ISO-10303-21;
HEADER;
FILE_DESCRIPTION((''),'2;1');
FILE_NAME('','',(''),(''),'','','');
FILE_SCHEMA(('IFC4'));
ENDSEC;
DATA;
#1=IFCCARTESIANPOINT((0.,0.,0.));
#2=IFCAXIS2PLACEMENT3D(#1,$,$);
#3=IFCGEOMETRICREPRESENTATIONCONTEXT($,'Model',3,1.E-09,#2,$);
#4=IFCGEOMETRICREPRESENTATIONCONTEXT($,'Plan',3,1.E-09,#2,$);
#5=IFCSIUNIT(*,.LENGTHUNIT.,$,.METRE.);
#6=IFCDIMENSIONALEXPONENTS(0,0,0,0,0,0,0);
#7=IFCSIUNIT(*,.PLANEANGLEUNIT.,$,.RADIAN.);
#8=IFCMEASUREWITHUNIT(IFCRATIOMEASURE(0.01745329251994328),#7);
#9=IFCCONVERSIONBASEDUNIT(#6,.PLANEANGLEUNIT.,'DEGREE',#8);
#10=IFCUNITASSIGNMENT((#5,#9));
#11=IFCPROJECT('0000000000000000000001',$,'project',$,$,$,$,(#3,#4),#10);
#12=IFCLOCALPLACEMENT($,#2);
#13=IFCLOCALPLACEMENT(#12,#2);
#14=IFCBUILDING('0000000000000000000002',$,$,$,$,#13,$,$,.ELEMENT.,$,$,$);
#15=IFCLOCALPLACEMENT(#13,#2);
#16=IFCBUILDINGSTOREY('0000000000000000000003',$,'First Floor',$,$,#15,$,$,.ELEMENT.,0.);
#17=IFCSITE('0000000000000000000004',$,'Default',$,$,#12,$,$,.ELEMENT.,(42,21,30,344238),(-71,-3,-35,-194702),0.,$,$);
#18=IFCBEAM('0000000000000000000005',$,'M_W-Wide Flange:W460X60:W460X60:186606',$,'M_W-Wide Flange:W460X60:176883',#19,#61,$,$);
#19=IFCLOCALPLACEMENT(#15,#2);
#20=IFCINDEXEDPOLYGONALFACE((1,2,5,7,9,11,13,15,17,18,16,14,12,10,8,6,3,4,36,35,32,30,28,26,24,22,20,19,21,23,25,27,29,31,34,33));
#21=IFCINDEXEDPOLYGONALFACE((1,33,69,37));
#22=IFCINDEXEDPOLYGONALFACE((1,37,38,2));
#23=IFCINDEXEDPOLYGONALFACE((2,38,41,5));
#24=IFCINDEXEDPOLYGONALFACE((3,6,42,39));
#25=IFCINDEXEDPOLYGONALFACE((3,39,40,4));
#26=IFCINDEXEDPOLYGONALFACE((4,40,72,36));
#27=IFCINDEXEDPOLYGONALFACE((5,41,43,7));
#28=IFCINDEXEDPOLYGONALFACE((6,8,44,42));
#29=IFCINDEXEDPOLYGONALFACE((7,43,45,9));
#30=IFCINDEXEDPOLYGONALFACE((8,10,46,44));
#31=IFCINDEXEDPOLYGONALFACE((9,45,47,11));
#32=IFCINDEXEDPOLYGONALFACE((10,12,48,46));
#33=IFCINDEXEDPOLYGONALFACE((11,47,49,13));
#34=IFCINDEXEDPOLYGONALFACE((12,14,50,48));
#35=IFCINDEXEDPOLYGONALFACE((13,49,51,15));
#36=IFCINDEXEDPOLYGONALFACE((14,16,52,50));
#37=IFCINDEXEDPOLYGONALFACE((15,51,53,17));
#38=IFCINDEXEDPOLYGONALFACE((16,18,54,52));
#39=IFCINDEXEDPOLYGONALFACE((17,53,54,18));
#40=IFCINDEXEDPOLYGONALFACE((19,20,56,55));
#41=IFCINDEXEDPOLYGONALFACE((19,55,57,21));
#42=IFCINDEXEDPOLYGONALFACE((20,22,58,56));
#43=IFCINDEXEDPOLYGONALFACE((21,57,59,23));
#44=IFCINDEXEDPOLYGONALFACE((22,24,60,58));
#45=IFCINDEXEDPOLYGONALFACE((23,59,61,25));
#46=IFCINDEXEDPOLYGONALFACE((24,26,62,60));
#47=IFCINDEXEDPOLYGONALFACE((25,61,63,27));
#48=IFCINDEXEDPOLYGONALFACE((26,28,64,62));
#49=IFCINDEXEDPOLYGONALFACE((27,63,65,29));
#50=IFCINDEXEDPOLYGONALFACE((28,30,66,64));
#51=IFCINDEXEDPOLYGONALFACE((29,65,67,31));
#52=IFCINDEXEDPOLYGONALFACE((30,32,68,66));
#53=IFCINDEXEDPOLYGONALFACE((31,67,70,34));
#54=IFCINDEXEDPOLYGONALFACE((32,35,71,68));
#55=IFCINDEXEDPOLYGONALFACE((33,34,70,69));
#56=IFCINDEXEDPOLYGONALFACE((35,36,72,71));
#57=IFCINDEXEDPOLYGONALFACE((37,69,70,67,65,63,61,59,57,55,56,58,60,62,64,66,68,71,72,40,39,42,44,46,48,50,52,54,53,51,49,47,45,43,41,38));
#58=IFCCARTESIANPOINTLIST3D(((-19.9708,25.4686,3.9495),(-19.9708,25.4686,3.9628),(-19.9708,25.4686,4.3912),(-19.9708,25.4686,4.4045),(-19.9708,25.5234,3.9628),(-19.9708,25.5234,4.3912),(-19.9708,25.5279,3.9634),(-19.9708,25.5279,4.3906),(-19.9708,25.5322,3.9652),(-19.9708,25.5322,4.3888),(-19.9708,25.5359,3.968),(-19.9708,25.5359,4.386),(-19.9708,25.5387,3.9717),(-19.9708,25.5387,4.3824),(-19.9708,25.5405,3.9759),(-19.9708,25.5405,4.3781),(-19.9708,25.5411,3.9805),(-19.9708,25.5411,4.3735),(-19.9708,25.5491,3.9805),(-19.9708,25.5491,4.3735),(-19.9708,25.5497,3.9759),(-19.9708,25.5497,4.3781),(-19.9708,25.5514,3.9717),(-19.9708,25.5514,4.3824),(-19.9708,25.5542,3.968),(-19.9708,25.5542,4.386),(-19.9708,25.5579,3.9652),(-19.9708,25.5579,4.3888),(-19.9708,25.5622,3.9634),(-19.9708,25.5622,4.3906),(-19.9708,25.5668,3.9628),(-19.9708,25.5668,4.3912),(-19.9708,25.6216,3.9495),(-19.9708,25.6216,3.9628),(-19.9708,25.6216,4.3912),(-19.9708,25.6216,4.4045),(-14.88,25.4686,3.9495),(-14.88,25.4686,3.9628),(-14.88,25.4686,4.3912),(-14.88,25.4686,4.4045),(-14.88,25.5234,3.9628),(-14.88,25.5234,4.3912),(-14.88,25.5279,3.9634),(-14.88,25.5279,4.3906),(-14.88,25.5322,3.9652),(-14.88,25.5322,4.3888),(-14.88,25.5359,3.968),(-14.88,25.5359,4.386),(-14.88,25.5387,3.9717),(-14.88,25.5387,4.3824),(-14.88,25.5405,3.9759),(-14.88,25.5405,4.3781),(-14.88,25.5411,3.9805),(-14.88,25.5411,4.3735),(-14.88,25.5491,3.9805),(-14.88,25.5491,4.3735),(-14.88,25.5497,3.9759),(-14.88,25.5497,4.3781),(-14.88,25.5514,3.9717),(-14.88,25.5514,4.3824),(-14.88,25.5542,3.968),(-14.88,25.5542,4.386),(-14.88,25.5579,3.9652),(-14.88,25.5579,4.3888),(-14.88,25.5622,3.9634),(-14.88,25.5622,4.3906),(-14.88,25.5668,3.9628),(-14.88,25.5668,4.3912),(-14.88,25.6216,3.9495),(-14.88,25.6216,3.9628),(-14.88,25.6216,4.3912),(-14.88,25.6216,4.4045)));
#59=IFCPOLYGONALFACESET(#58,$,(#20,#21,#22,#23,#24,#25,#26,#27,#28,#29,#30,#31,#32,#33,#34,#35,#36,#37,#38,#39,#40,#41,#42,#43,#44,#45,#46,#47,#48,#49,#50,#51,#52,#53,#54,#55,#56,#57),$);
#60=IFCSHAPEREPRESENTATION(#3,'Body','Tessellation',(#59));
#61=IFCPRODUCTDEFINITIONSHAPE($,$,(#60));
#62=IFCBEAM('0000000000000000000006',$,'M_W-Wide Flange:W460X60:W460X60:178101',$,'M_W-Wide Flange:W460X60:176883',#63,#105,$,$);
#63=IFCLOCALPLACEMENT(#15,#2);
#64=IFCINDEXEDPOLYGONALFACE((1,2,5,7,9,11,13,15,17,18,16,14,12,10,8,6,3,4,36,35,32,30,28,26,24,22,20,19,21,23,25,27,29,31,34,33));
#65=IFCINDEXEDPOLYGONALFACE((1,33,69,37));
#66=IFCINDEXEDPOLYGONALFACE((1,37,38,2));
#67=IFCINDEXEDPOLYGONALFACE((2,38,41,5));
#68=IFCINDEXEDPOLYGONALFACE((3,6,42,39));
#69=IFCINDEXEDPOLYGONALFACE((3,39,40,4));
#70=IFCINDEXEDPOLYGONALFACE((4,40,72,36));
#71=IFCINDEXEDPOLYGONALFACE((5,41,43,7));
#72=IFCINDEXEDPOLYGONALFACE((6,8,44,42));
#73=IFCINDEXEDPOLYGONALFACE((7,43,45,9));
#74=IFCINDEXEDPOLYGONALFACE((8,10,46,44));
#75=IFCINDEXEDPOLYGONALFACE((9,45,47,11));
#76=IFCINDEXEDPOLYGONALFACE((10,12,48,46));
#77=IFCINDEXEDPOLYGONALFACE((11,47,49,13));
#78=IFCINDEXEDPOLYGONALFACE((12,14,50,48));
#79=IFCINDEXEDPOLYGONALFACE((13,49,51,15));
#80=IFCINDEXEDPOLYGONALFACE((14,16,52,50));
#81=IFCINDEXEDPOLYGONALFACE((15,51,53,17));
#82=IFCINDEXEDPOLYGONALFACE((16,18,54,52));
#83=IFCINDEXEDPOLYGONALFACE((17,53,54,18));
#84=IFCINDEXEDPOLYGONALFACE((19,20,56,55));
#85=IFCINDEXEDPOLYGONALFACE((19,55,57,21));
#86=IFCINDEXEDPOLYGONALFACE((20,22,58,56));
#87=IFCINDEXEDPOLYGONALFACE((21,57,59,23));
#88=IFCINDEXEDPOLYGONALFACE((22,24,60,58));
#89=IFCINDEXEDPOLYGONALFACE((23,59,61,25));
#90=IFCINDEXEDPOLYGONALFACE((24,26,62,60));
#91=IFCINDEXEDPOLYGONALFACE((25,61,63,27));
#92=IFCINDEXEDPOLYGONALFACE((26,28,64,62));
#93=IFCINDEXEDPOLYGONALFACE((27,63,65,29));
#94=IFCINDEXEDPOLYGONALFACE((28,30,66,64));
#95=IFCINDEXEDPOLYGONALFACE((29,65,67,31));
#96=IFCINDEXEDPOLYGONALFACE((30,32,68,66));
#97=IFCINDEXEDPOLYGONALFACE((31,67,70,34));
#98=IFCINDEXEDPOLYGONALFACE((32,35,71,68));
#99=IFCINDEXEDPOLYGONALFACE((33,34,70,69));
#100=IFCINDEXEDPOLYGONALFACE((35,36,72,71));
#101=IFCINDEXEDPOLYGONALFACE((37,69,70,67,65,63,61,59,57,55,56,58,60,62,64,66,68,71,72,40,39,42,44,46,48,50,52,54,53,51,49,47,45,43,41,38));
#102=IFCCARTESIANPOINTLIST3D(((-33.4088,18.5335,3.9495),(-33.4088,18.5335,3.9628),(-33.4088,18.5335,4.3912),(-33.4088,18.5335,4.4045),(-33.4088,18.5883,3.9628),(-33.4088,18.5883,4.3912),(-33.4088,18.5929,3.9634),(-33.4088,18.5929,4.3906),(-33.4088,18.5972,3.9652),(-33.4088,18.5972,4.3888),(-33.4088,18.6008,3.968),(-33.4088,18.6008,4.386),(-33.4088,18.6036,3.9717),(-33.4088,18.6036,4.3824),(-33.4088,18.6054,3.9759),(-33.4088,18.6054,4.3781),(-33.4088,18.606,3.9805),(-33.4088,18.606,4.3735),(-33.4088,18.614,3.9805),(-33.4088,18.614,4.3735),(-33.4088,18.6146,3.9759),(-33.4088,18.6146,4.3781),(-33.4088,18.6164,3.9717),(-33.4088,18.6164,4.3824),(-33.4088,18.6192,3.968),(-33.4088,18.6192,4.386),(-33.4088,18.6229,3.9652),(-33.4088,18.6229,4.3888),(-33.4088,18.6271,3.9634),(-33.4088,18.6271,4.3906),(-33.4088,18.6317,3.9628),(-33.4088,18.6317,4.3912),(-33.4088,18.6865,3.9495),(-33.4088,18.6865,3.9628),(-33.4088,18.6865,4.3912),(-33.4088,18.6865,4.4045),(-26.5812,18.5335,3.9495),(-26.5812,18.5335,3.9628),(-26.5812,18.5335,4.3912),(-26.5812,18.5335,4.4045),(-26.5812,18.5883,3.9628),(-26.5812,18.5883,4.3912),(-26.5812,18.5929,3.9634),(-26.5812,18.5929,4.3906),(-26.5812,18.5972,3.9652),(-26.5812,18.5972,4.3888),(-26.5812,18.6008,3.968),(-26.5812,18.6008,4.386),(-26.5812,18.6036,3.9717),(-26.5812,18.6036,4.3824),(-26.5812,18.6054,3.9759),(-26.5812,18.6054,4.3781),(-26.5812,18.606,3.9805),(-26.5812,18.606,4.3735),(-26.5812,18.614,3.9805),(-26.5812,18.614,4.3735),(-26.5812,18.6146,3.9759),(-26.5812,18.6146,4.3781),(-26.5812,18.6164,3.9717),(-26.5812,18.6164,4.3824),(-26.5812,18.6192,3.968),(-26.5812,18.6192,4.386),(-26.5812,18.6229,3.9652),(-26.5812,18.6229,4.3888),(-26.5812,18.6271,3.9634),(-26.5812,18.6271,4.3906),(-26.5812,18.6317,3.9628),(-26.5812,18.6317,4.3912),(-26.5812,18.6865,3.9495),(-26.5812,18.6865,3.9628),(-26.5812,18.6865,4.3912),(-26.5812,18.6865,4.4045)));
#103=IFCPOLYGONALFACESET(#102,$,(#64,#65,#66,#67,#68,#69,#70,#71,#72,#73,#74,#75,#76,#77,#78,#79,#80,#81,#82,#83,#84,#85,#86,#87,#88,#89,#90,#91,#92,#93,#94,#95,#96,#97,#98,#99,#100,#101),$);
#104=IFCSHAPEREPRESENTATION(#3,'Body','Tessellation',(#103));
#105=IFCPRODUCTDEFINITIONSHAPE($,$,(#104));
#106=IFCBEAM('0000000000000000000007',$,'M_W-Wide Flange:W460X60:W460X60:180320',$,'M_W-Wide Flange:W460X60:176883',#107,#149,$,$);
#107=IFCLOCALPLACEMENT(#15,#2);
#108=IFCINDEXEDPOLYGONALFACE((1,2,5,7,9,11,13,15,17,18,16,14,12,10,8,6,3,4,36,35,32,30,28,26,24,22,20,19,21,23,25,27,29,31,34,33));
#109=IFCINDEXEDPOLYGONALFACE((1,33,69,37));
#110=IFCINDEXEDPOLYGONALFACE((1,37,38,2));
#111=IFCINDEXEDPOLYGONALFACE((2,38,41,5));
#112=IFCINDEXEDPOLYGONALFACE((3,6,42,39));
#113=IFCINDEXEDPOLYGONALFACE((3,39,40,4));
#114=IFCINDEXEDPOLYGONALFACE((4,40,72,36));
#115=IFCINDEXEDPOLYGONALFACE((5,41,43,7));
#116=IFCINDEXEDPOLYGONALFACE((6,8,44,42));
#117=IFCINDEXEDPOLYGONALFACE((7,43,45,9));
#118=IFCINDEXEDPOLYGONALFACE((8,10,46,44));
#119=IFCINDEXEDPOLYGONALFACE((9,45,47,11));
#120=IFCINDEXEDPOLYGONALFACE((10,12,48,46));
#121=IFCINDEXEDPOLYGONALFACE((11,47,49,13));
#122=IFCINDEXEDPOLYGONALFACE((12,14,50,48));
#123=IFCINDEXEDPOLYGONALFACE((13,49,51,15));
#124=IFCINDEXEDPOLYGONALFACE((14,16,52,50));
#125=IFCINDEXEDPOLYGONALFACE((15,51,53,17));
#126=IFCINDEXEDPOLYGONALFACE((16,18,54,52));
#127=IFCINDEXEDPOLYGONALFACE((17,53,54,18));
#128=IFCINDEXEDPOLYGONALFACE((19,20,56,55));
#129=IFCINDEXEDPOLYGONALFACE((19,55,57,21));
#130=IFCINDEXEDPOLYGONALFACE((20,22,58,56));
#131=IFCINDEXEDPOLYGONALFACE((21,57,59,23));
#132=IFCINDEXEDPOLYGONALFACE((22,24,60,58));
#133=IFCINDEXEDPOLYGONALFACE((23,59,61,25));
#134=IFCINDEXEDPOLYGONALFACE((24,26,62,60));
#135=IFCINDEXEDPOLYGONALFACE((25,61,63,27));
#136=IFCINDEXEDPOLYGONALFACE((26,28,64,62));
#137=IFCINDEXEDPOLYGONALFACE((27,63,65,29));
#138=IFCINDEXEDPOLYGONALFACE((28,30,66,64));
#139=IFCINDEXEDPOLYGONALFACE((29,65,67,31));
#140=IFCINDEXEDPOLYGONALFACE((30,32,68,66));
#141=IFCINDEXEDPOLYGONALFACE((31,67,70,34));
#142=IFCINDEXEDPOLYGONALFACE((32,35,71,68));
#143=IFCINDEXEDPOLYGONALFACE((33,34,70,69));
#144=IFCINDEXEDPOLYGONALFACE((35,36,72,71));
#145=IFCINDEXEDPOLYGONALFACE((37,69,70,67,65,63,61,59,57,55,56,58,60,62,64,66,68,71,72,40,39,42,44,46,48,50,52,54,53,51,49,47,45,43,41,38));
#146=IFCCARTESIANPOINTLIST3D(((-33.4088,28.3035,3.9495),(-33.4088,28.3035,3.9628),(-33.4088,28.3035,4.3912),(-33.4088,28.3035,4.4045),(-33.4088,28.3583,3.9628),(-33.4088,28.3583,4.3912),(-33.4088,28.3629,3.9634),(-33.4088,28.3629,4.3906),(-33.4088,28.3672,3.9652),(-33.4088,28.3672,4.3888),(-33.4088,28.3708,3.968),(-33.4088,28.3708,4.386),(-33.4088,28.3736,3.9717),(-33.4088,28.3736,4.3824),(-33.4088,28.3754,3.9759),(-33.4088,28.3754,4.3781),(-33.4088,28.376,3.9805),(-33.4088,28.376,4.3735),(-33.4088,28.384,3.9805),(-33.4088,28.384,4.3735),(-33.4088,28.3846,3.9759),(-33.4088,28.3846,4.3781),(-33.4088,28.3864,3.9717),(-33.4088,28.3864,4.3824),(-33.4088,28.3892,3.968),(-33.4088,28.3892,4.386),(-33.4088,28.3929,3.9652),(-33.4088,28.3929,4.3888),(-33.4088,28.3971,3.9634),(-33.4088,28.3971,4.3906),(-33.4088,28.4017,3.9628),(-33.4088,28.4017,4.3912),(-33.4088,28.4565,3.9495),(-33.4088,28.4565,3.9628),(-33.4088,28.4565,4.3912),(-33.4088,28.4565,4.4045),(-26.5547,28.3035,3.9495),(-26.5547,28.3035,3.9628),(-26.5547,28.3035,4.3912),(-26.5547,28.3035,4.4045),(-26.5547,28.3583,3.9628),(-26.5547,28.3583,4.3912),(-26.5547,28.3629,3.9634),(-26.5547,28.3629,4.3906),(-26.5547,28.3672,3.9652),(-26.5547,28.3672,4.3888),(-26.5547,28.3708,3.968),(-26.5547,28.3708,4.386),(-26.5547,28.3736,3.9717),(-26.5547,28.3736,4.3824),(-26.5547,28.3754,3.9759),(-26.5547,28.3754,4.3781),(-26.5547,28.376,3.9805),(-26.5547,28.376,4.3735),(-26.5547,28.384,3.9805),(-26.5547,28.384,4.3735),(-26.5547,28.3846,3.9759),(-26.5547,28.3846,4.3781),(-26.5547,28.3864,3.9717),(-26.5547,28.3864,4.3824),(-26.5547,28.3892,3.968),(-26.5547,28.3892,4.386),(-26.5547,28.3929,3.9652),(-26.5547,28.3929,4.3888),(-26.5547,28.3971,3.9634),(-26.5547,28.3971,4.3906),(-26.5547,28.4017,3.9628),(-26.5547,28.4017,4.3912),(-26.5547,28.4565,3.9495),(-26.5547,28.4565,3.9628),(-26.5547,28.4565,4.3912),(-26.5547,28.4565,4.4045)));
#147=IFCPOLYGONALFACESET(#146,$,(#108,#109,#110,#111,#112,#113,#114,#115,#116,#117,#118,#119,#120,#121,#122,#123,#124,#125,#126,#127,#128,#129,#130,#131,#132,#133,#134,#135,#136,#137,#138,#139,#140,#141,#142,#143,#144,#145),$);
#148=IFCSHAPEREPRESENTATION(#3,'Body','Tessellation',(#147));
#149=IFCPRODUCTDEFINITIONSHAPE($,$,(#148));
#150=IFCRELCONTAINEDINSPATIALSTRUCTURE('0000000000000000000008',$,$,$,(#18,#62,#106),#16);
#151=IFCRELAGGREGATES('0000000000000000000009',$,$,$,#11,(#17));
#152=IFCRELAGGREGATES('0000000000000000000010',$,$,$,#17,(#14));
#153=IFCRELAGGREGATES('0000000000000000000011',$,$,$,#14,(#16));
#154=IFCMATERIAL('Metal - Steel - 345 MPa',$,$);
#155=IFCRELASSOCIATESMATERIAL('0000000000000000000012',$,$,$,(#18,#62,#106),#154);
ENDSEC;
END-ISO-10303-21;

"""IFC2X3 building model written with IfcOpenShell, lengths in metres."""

from ifc_helpers import new_model, entity, si_unit, converted_unit, frame, frame_2d, origin, place, context, project, spatial, polyline, circle_curve, parameter, trimmed, segment, composite_curve, outline, extrude, material, element, save


model = new_model("IFC2X3")

# Units and contexts
model_context = context("Model", 3, precision=1e-09, world=origin())
plan_context = context("Plan", 3, precision=1e-09, world=origin())
ifc_project = project(units=[si_unit("LENGTHUNIT", "METRE"), converted_unit("PLANEANGLEUNIT", "DEGREE", entity("IfcRatioMeasure", 0.01745329251994328), si_unit("PLANEANGLEUNIT", "RADIAN"), dimensions=[0, 0, 0, 0, 0, 0, 0])], contexts=[model_context, plan_context])

# Site, building, storey
site_placement = place(None, origin())
site = spatial("IfcSite", under=ifc_project, at=site_placement, Name="Default", CompositionType="ELEMENT", RefLatitude=(42, 21, 30, 344238), RefLongitude=(-71, -3, -35, -194702), RefElevation=0.0)
building_placement = place(site_placement, origin())
building = spatial("IfcBuilding", under=site, at=building_placement, CompositionType="ELEMENT")
storey_placement = place(building_placement, origin())
storey = spatial("IfcBuildingStorey", under=building, at=storey_placement, Name="First Floor", CompositionType="ELEMENT", Elevation=0.0)

# Beams
ifc_material_1 = material(Name="Metal - Steel - 345 MPa")
beam_1_placement = place(storey_placement, frame((-19.7579, 25.5451, 4.4045), z_axis=(0.0, 0.0, 1.0), x_axis=(0.0, -1.0, 0.0)))
element("IfcBeam", 1, at=beam_1_placement, inside=storey, material=ifc_material_1, Name="M_W-Wide Flange:W460X60:W460X60:186606", ObjectType="M_W-Wide Flange:W460X60:176883", context=model_context, shape_type="SweptSolid", body=[
    extrude(outline(composite_curve([segment(polyline([(-0.0765, -0.2142), (-0.0765, -0.2275)]), True, "CONTINUOUS"), segment(polyline([(-0.0765, -0.2275), (0.0765, -0.2275)]), True, "CONTINUOUS"), segment(polyline([(0.0765, -0.2275), (0.0765, -0.2142)]), True, "CONTINUOUS"), segment(polyline([(0.0765, -0.2142), (0.0217, -0.2142)]), True, "CONTINUOUS"), segment(trimmed(circle_curve(frame_2d((0.0217, -0.1965), x_axis=(1.0, 0.0)), 0.0177), [parameter(180.0)], [parameter(270.0)], True, "PARAMETER"), False, "CONTINUOUS"), segment(polyline([(0.004, -0.1965), (0.004, 0.1965)]), True, "CONTINUOUS"), segment(trimmed(circle_curve(frame_2d((0.0217, 0.1965), x_axis=(1.0, 0.0)), 0.0177), [parameter(90.0)], [parameter(180.0)], True, "PARAMETER"), False, "CONTINUOUS"), segment(polyline([(0.0217, 0.2142), (0.0765, 0.2142)]), True, "CONTINUOUS"), segment(polyline([(0.0765, 0.2142), (0.0765, 0.2275)]), True, "CONTINUOUS"), segment(polyline([(0.0765, 0.2275), (-0.0765, 0.2275)]), True, "CONTINUOUS"), segment(polyline([(-0.0765, 0.2275), (-0.0765, 0.2142)]), True, "CONTINUOUS"), segment(polyline([(-0.0765, 0.2142), (-0.0217, 0.2142)]), True, "CONTINUOUS"), segment(trimmed(circle_curve(frame_2d((-0.0217, 0.1965), x_axis=(1.0, 0.0)), 0.0177), [parameter(360.0)], [parameter(90.0)], True, "PARAMETER"), False, "CONTINUOUS"), segment(polyline([(-0.004, 0.1965), (-0.004, -0.1965)]), True, "CONTINUOUS"), segment(trimmed(circle_curve(frame_2d((-0.0217, -0.1965), x_axis=(1.0, 0.0)), 0.0177), [parameter(270.0)], [parameter(0.0)], True, "PARAMETER"), False, "CONTINUOUS"), segment(polyline([(-0.0217, -0.2142), (-0.0765, -0.2142)]), True, "CONTINUOUS")], self_intersect=False)), frame((0.0, -0.2129, -0.2275), z_axis=(0.0, -1.0, 0.0), x_axis=(1.0, 0.0, 0.0)), (0.0, 0.0, -1.0), 5.0908),
])
beam_2_placement = place(storey_placement, frame((-33.5519, 18.61, 4.4045), z_axis=(0.0, 0.0, 1.0), x_axis=(0.0, -1.0, 0.0)))
element("IfcBeam", 2, at=beam_2_placement, inside=storey, material=ifc_material_1, Name="M_W-Wide Flange:W460X60:W460X60:178101", ObjectType="M_W-Wide Flange:W460X60:176883", context=model_context, shape_type="SweptSolid", body=[
    extrude(outline(composite_curve([segment(polyline([(-0.0765, -0.2142), (-0.0765, -0.2275)]), True, "CONTINUOUS"), segment(polyline([(-0.0765, -0.2275), (0.0765, -0.2275)]), True, "CONTINUOUS"), segment(polyline([(0.0765, -0.2275), (0.0765, -0.2142)]), True, "CONTINUOUS"), segment(polyline([(0.0765, -0.2142), (0.0217, -0.2142)]), True, "CONTINUOUS"), segment(trimmed(circle_curve(frame_2d((0.0217, -0.1965), x_axis=(0.0, -1.0)), 0.0177), [parameter(270.0)], [parameter(360.0)], True, "PARAMETER"), False, "CONTINUOUS"), segment(polyline([(0.004, -0.1965), (0.004, 0.1965)]), True, "CONTINUOUS"), segment(trimmed(circle_curve(frame_2d((0.0217, 0.1965), x_axis=(-1.0, 0.0)), 0.0177), [parameter(270.0)], [parameter(360.0)], True, "PARAMETER"), False, "CONTINUOUS"), segment(polyline([(0.0217, 0.2142), (0.0765, 0.2142)]), True, "CONTINUOUS"), segment(polyline([(0.0765, 0.2142), (0.0765, 0.2275)]), True, "CONTINUOUS"), segment(polyline([(0.0765, 0.2275), (-0.0765, 0.2275)]), True, "CONTINUOUS"), segment(polyline([(-0.0765, 0.2275), (-0.0765, 0.2142)]), True, "CONTINUOUS"), segment(polyline([(-0.0765, 0.2142), (-0.0217, 0.2142)]), True, "CONTINUOUS"), segment(trimmed(circle_curve(frame_2d((-0.0217, 0.1965), x_axis=(0.0, 1.0)), 0.0177), [parameter(270.0)], [parameter(360.0)], True, "PARAMETER"), False, "CONTINUOUS"), segment(polyline([(-0.004, 0.1965), (-0.004, -0.1965)]), True, "CONTINUOUS"), segment(trimmed(circle_curve(frame_2d((-0.0217, -0.1965), x_axis=(1.0, 0.0)), 0.0177), [parameter(270.0)], [parameter(0.0)], True, "PARAMETER"), False, "CONTINUOUS"), segment(polyline([(-0.0217, -0.2142), (-0.0765, -0.2142)]), True, "CONTINUOUS")], self_intersect=False)), frame((0.0, 0.1431, -0.2275), z_axis=(0.0, -1.0, 0.0), x_axis=(1.0, 0.0, 0.0)), (0.0, 0.0, -1.0), 6.8276),
])
beam_3_placement = place(storey_placement, frame((-26.4381, 28.38, 4.4045), z_axis=(0.0, 0.0, 1.0), x_axis=(0.0, 1.0, 0.0)))
element("IfcBeam", 3, at=beam_3_placement, inside=storey, material=ifc_material_1, Name="M_W-Wide Flange:W460X60:W460X60:180320", ObjectType="M_W-Wide Flange:W460X60:176883", context=model_context, shape_type="SweptSolid", body=[
    extrude(outline(composite_curve([segment(polyline([(0.2142, -0.0765), (0.2275, -0.0765)]), True, "CONTINUOUS"), segment(polyline([(0.2275, -0.0765), (0.2275, 0.0765)]), True, "CONTINUOUS"), segment(polyline([(0.2275, 0.0765), (0.2142, 0.0765)]), True, "CONTINUOUS"), segment(polyline([(0.2142, 0.0765), (0.2142, 0.0217)]), True, "CONTINUOUS"), segment(trimmed(circle_curve(frame_2d((0.1965, 0.0217), x_axis=(1.0, 0.0)), 0.0177), [parameter(270.0)], [parameter(360.0)], True, "PARAMETER"), False, "CONTINUOUS"), segment(polyline([(0.1965, 0.004), (-0.1965, 0.004)]), True, "CONTINUOUS"), segment(trimmed(circle_curve(frame_2d((-0.1965, 0.0217), x_axis=(0.0, -1.0)), 0.0177), [parameter(270.0)], [parameter(360.0)], True, "PARAMETER"), False, "CONTINUOUS"), segment(polyline([(-0.2142, 0.0217), (-0.2142, 0.0765)]), True, "CONTINUOUS"), segment(polyline([(-0.2142, 0.0765), (-0.2275, 0.0765)]), True, "CONTINUOUS"), segment(polyline([(-0.2275, 0.0765), (-0.2275, -0.0765)]), True, "CONTINUOUS"), segment(polyline([(-0.2275, -0.0765), (-0.2142, -0.0765)]), True, "CONTINUOUS"), segment(polyline([(-0.2142, -0.0765), (-0.2142, -0.0217)]), True, "CONTINUOUS"), segment(trimmed(circle_curve(frame_2d((-0.1965, -0.0217), x_axis=(-1.0, 0.0)), 0.0177), [parameter(270.0)], [parameter(360.0)], True, "PARAMETER"), False, "CONTINUOUS"), segment(polyline([(-0.1965, -0.004), (0.1965, -0.004)]), True, "CONTINUOUS"), segment(trimmed(circle_curve(frame_2d((0.1965, -0.0217), x_axis=(0.0, 1.0)), 0.0177), [parameter(270.0)], [parameter(0.0)], True, "PARAMETER"), False, "CONTINUOUS"), segment(polyline([(0.2142, -0.0217), (0.2142, -0.0765)]), True, "CONTINUOUS")], self_intersect=False)), frame((0.0, 6.9707, -0.2275), z_axis=(0.0, -1.0, 0.0), x_axis=(0.0, 0.0, -1.0)), (0.0, 0.0, 1.0), 6.8541),
])

save(model, "model.ifc")
